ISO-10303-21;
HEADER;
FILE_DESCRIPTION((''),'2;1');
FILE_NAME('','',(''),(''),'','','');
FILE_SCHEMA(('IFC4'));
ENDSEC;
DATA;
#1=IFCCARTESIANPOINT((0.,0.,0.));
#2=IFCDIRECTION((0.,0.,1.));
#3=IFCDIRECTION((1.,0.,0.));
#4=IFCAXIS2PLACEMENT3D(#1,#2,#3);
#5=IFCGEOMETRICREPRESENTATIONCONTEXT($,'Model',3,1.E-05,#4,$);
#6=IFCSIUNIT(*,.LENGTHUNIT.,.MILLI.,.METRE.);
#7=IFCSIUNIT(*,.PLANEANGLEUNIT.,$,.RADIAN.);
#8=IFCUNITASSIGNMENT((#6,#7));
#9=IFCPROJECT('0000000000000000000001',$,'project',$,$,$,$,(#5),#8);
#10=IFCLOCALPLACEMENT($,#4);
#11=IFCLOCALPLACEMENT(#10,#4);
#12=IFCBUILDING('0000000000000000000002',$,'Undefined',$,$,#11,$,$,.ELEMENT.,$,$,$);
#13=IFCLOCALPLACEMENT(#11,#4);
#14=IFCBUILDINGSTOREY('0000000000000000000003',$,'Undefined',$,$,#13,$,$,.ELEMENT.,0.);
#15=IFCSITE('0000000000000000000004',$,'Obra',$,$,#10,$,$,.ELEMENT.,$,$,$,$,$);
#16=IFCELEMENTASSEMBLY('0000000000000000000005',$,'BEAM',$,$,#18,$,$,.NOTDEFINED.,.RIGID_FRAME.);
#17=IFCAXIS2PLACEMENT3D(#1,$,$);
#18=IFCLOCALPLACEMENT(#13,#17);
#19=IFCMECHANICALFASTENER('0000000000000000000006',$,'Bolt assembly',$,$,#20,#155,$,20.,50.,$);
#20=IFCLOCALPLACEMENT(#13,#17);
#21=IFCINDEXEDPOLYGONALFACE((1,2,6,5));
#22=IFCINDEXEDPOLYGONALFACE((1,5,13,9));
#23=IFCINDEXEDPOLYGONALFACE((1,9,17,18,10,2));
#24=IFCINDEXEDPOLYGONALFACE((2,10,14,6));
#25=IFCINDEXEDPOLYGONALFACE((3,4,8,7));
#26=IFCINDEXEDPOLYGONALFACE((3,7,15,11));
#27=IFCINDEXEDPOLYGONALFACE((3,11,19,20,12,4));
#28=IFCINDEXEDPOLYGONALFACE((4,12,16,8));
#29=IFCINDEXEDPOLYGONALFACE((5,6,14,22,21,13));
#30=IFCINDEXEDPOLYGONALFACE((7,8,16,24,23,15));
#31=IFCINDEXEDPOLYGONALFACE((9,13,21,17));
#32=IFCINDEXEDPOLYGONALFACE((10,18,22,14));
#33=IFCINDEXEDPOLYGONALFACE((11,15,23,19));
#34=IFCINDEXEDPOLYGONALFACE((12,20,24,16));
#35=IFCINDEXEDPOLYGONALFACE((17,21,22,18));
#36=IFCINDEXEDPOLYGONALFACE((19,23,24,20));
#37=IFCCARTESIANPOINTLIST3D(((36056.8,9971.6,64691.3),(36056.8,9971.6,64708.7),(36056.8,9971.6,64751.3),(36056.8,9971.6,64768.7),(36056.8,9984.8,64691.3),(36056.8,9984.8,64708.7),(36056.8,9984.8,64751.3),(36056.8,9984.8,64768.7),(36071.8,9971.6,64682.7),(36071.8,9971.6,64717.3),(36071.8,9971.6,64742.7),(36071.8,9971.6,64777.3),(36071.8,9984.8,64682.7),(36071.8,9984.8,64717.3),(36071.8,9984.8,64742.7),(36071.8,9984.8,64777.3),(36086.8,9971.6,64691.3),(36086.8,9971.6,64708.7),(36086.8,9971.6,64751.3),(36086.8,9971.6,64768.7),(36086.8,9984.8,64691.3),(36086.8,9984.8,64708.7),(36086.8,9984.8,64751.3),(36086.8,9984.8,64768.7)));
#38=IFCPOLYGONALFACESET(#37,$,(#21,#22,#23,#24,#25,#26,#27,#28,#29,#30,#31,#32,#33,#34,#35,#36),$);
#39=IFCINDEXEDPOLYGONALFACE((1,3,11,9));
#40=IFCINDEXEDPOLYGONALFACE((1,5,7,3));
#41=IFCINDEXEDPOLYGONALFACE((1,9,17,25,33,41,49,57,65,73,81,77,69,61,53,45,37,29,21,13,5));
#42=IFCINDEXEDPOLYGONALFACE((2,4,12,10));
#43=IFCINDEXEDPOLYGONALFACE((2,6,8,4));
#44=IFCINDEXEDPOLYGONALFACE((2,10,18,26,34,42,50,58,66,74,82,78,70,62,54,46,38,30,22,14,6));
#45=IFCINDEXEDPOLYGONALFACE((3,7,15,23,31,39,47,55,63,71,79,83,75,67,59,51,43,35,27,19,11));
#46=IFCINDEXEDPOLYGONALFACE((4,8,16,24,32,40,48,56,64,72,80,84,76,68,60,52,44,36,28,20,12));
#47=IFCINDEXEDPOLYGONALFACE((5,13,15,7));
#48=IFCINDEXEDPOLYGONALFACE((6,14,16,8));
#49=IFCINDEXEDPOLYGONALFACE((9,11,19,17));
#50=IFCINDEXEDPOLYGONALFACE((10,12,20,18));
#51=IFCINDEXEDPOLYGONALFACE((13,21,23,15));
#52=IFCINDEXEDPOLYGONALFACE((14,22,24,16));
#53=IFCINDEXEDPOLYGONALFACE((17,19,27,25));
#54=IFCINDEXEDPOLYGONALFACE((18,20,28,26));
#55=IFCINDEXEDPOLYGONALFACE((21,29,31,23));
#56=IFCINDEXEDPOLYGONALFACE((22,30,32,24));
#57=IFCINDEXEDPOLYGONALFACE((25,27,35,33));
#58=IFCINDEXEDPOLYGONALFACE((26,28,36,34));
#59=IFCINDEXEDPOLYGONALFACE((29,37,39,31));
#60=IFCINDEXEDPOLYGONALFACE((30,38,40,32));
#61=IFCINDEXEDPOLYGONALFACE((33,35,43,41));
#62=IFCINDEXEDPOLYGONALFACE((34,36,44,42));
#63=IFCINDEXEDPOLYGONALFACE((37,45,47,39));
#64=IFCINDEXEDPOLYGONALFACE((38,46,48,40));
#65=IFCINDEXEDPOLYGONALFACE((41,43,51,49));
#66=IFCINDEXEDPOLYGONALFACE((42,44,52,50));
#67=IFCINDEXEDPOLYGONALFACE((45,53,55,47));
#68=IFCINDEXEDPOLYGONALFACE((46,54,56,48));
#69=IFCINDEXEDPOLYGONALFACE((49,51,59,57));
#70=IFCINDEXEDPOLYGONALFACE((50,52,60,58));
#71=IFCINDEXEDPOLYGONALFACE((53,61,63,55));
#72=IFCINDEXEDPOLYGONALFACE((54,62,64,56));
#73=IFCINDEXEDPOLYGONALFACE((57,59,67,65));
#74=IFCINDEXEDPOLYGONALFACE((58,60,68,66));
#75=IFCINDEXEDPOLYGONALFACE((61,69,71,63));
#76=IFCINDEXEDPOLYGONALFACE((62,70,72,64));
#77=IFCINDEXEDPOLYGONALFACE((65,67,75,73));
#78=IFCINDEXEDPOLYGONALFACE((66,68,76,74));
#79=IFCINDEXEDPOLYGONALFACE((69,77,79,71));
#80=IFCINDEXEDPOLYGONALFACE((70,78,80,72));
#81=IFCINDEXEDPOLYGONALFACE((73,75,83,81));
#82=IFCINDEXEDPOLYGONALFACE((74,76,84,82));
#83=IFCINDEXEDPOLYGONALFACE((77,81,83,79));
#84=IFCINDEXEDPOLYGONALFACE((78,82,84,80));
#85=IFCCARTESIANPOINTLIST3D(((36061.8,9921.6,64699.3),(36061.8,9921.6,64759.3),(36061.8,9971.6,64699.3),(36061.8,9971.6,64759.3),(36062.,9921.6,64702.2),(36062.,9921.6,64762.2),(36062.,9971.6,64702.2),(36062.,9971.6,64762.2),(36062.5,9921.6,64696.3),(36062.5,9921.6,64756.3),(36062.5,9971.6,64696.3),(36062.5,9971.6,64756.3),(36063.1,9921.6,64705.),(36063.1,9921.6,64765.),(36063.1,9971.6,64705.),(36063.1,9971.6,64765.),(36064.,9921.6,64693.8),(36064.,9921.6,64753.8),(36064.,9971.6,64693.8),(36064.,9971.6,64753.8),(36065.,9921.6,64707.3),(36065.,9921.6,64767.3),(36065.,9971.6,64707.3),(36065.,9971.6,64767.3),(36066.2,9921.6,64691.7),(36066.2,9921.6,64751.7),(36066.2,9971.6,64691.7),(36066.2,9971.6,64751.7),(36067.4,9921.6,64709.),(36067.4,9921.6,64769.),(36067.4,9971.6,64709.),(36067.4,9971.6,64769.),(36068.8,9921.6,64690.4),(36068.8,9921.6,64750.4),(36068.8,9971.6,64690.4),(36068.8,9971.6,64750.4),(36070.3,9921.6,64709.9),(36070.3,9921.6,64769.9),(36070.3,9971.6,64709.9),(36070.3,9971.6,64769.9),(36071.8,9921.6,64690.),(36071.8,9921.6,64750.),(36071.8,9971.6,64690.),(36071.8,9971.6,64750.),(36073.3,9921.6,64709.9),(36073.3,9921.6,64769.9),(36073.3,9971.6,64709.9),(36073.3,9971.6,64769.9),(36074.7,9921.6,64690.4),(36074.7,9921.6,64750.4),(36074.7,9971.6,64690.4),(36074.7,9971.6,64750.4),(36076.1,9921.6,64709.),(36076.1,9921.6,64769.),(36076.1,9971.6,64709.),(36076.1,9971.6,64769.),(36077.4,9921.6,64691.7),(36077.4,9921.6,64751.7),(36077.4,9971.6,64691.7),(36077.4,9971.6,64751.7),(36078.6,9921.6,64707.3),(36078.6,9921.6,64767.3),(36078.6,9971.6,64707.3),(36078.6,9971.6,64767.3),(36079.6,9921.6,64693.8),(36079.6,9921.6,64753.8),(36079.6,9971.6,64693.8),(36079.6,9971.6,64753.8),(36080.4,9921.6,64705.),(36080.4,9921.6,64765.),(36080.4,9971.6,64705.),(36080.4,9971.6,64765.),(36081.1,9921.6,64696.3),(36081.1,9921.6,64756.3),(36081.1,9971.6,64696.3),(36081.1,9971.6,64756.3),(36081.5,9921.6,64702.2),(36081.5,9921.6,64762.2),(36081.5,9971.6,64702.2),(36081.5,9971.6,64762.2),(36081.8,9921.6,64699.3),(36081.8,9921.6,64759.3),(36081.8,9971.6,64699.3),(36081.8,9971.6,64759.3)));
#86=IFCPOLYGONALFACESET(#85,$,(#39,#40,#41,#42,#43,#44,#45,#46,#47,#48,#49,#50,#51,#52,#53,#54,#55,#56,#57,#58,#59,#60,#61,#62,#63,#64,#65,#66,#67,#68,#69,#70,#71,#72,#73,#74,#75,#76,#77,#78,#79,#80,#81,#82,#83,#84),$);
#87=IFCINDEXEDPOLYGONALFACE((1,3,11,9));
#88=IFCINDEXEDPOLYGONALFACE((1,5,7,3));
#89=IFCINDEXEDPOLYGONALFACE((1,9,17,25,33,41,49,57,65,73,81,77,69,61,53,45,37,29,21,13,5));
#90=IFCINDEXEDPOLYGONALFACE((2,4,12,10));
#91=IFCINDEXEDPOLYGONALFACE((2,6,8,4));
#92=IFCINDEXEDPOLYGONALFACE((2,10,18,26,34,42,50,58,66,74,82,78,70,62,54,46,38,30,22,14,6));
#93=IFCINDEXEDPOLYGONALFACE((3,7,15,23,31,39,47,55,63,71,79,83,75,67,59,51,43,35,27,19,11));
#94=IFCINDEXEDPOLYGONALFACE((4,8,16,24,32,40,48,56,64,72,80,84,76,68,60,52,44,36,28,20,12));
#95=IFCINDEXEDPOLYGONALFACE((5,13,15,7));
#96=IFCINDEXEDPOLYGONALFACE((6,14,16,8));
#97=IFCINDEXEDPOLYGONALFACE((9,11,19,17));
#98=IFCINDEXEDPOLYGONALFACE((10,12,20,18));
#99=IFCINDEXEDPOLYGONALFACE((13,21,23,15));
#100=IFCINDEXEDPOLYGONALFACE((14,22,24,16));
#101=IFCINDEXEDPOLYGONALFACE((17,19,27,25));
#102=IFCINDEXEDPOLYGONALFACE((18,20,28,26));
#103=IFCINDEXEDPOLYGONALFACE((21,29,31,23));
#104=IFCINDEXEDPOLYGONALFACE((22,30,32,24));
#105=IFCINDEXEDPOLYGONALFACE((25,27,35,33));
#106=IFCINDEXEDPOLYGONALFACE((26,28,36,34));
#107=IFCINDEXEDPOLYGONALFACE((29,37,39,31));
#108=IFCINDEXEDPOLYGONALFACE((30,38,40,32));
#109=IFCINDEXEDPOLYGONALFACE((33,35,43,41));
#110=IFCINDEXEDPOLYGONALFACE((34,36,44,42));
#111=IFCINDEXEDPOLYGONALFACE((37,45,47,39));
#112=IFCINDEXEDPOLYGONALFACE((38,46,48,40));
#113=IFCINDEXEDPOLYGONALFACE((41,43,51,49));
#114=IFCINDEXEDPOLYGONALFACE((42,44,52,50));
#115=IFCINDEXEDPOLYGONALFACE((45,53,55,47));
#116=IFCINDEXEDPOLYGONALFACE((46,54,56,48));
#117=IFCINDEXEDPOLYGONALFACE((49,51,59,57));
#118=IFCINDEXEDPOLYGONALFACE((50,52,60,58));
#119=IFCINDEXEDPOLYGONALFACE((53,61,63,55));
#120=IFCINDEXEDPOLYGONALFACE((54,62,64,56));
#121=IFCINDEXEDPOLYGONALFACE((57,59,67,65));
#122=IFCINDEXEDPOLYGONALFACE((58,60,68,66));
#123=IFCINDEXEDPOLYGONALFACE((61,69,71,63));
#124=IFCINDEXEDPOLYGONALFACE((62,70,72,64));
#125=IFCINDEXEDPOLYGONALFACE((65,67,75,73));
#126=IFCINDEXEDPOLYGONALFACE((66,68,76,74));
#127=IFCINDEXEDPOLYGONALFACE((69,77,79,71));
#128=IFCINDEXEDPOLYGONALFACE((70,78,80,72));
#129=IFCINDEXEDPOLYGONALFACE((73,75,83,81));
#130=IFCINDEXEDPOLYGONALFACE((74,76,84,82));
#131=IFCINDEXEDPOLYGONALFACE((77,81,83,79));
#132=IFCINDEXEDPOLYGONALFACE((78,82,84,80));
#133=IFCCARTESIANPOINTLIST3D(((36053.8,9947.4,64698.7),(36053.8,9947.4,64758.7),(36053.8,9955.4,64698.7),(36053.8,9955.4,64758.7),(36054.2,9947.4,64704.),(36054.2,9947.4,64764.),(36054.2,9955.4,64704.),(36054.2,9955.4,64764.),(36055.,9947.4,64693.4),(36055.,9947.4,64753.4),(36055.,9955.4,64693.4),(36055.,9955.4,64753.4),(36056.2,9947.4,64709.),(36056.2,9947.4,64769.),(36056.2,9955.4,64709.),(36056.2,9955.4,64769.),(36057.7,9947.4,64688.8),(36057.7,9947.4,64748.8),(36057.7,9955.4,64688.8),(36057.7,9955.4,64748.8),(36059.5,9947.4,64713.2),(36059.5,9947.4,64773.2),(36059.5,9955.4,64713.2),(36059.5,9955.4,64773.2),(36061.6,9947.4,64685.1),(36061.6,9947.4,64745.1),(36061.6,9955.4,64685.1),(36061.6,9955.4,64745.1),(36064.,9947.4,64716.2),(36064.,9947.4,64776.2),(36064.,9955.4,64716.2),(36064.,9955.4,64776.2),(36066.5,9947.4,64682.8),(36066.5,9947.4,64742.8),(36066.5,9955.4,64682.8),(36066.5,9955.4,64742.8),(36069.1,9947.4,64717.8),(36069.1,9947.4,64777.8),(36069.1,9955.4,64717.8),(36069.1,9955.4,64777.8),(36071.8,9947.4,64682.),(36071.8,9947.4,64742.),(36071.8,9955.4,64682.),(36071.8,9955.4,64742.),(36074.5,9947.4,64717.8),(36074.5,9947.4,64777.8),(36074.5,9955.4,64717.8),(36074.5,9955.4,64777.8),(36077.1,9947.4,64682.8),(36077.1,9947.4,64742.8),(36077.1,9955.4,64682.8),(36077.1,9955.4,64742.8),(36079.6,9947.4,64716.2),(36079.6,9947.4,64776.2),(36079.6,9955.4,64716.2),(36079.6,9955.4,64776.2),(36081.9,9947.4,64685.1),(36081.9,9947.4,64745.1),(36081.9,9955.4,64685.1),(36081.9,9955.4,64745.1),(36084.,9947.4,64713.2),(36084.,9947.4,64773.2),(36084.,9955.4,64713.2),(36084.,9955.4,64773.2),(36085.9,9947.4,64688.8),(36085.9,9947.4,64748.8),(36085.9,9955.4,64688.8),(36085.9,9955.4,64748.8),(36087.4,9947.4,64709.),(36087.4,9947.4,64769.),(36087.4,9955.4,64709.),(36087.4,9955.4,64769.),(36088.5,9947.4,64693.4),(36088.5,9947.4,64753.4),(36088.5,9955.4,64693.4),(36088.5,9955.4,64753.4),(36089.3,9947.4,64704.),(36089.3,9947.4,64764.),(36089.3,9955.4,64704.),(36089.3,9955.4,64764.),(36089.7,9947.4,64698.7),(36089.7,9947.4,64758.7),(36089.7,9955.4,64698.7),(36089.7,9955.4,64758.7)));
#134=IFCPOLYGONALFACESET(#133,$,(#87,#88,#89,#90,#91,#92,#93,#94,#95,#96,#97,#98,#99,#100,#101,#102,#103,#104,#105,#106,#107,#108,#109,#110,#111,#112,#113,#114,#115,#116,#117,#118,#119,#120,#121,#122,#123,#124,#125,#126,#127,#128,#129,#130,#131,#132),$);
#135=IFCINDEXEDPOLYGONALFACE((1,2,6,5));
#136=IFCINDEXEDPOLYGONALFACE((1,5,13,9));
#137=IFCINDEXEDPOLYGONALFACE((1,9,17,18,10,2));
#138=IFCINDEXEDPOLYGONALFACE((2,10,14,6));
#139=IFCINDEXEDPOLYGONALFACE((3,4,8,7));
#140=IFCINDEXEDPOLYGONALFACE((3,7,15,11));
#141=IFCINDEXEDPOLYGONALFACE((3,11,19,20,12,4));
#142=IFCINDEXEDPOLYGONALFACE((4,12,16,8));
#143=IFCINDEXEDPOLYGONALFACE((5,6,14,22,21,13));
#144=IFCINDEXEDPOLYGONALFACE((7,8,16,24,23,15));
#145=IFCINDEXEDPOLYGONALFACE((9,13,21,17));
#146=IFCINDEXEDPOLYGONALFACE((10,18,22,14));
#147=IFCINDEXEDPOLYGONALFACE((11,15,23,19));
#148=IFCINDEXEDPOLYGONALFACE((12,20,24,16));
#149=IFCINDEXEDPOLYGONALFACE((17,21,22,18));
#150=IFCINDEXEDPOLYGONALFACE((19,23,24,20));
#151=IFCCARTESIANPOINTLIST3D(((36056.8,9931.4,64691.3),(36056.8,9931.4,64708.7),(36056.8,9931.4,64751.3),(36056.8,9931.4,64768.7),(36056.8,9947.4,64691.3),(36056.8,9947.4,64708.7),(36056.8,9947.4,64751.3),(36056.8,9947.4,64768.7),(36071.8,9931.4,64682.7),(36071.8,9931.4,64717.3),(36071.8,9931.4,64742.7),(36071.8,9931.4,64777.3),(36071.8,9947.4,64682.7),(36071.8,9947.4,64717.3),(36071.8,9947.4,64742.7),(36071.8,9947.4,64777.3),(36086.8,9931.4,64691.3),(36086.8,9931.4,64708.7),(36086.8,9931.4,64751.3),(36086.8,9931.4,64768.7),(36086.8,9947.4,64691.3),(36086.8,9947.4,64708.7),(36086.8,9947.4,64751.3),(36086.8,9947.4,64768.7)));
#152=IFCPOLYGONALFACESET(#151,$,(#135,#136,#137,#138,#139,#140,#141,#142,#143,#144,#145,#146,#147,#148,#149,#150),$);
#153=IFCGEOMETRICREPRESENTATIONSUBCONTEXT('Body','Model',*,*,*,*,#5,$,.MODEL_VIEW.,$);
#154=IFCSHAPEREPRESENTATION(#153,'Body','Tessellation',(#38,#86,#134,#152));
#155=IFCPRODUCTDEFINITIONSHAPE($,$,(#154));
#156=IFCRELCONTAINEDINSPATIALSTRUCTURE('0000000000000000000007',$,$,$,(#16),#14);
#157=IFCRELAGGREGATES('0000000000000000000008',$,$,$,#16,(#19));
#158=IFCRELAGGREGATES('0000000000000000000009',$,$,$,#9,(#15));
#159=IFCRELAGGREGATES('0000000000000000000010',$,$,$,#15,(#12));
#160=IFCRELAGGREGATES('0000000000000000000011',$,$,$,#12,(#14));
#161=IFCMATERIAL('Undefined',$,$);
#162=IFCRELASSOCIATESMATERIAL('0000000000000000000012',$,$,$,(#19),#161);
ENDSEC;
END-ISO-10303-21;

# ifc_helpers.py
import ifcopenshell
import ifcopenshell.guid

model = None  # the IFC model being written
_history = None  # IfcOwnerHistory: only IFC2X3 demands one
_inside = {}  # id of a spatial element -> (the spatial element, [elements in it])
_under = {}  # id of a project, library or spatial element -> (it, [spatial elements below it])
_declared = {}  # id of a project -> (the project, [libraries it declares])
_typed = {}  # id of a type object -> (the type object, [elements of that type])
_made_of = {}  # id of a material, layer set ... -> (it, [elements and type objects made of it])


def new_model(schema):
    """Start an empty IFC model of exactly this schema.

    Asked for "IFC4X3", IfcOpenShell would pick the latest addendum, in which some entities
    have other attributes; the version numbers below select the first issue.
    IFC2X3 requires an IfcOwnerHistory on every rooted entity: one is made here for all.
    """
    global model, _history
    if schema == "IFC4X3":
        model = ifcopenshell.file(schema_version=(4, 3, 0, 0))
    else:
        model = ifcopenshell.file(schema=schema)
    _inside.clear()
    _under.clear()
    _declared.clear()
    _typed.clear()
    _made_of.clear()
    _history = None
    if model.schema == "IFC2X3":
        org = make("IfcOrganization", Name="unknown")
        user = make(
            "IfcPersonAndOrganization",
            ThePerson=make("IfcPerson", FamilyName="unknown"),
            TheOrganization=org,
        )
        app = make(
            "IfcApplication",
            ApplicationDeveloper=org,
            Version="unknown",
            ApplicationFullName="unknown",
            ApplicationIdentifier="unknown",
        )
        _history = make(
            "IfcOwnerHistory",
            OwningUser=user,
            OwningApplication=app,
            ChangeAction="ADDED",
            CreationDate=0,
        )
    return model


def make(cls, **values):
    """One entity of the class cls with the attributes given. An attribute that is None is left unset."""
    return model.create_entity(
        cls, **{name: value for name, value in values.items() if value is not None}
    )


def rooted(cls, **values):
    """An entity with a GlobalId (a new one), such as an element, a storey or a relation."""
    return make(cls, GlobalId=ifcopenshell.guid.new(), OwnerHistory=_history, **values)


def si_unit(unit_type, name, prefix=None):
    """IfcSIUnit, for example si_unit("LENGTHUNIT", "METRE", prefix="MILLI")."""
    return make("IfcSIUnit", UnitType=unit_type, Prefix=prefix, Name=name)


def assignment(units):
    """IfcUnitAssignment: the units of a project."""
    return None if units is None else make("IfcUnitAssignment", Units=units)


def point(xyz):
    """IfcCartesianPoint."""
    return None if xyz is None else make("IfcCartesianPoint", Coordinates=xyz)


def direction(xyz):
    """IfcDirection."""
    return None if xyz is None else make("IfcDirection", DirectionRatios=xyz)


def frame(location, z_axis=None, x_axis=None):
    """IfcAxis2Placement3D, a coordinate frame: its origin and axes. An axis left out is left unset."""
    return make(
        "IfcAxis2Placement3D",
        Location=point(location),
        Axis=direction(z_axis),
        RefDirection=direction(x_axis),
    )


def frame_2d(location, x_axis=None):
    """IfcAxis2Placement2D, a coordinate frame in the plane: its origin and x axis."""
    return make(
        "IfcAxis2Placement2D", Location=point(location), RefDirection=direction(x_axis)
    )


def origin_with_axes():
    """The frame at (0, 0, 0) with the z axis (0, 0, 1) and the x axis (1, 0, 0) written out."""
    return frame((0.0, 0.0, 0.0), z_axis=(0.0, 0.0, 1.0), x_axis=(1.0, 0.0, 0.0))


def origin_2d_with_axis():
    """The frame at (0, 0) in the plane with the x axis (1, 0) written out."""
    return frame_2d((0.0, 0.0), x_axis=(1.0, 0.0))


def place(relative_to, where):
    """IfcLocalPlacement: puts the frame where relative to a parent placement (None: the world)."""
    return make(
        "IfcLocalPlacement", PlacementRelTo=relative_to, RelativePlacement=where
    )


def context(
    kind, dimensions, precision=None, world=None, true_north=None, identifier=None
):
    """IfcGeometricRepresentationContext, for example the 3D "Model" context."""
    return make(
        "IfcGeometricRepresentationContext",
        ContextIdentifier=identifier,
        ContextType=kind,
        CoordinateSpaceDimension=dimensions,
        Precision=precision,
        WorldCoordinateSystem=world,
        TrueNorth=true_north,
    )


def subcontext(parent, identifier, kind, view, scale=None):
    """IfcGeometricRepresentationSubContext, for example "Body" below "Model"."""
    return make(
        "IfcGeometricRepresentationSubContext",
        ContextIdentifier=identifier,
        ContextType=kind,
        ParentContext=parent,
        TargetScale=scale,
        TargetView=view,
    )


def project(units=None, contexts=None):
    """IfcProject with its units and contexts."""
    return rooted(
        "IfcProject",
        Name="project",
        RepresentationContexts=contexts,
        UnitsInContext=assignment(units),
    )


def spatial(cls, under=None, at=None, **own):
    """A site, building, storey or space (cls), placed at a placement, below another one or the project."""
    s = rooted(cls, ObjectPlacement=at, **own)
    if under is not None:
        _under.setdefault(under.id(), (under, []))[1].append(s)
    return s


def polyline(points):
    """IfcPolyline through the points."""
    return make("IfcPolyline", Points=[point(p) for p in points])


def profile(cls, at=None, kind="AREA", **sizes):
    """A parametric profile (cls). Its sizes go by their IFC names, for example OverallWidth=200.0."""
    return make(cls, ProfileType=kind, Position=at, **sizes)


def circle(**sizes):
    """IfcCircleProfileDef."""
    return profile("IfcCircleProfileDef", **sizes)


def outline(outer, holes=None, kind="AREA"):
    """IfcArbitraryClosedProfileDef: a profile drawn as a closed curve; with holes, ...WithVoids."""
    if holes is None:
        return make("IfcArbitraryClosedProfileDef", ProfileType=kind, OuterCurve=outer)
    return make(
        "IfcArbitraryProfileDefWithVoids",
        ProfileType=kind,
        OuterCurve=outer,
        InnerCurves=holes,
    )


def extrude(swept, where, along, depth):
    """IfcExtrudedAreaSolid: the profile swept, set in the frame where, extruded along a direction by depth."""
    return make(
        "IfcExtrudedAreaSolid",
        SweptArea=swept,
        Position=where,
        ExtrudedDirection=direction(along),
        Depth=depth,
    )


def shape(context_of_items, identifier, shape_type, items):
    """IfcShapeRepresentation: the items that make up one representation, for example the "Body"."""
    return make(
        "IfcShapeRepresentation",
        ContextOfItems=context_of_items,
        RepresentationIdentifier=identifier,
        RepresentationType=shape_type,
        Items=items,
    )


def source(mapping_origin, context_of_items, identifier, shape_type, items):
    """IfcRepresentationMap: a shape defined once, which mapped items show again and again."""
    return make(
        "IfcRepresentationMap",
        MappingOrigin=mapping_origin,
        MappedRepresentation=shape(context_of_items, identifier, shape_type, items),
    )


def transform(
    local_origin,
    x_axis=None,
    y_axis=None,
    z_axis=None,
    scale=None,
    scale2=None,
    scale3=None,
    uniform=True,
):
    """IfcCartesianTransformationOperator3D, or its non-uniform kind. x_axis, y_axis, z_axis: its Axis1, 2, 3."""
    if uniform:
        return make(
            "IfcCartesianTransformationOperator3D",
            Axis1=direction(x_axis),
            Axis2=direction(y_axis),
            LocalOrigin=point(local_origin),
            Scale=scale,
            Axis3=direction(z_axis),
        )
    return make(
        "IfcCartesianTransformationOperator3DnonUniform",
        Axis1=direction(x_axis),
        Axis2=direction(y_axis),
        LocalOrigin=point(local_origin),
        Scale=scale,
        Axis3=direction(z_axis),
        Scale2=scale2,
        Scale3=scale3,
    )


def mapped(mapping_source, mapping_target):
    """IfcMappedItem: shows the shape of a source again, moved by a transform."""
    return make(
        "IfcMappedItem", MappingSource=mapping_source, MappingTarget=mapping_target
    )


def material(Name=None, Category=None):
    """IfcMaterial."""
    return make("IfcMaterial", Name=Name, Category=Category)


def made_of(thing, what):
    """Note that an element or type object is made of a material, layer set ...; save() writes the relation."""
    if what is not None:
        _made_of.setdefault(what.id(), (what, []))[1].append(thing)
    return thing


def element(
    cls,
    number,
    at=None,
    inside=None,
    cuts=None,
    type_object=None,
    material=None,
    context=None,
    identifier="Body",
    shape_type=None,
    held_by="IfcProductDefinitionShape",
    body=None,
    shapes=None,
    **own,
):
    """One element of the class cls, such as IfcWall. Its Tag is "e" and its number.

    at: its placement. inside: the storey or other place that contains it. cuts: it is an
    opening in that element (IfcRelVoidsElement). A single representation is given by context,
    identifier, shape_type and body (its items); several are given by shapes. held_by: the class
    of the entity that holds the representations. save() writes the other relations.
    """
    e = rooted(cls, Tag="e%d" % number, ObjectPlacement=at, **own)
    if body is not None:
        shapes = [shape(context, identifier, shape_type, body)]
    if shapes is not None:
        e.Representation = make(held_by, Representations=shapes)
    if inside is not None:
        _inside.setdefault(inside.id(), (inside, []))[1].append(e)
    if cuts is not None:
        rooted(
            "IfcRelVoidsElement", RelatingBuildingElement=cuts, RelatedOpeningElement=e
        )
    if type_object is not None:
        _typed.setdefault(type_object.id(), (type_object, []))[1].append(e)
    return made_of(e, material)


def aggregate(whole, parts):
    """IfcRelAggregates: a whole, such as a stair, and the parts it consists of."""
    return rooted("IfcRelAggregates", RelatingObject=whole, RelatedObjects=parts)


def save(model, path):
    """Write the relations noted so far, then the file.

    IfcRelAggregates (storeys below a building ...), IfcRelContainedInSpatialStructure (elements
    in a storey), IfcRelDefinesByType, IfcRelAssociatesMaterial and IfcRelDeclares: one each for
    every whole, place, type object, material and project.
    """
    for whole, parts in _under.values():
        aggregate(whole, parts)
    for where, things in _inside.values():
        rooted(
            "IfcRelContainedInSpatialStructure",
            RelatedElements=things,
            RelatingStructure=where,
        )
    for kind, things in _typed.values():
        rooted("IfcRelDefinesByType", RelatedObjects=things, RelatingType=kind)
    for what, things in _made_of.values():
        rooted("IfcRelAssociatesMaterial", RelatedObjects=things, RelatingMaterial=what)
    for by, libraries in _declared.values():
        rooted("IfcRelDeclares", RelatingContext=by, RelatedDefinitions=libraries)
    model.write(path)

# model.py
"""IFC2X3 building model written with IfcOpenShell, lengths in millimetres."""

from ifc_helpers import new_model, si_unit, frame, origin_with_axes, origin_2d_with_axis, place, context, subcontext, project, spatial, polyline, circle, outline, extrude, source, transform, mapped, material, element, aggregate, save


model = new_model("IFC2X3")

# Units and contexts
model_context = context("Model", 3, precision=1e-05, world=origin_with_axes())
body_context = subcontext(model_context, "Body", "Model", "MODEL_VIEW")
ifc_project = project(units=[si_unit("LENGTHUNIT", "METRE", prefix="MILLI"), si_unit("PLANEANGLEUNIT", "RADIAN")], contexts=[model_context])

# Site, building, storey
site_placement = place(None, origin_with_axes())
site = spatial("IfcSite", under=ifc_project, at=site_placement, Name="Obra", CompositionType="ELEMENT")
building_placement = place(site_placement, origin_with_axes())
building = spatial("IfcBuilding", under=site, at=building_placement, Name="Undefined", CompositionType="ELEMENT")
storey_placement = place(building_placement, origin_with_axes())
storey = spatial("IfcBuildingStorey", under=building, at=storey_placement, Name="Undefined", CompositionType="ELEMENT", Elevation=0.0)

# Shared definitions
ifc_material = material(Name="Undefined")

# Element assembly, mechanical fastener
shared_shape_1 = source(origin_with_axes(), body_context, "Body", "SweptSolid", [
    extrude(outline(polyline([(17.3, 0.0), (8.7, 15.0), (-8.7, 15.0), (-17.3, 0.0), (-8.7, -15.0), (8.7, -15.0), (17.3, 0.0)])), frame((0.0, -26.3, 0.0), z_axis=(0.0, 1.0, 0.0), x_axis=(1.0, 0.0, 0.0)), (0.0, 0.0, 1.0), 13.2),
    extrude(circle(Radius=10.0, at=origin_2d_with_axis()), frame((0.0, -13.1, 0.0), z_axis=(0.0, 1.0, 0.0), x_axis=(1.0, 0.0, 0.0)), (0.0, 0.0, 1.0), 50.0),
    extrude(circle(Radius=18.0, at=origin_2d_with_axis()), frame((0.0, 3.1, 0.0), z_axis=(0.0, 1.0, 0.0), x_axis=(1.0, 0.0, 0.0)), (0.0, 0.0, 1.0), 8.0),
    extrude(outline(polyline([(17.3, 0.0), (8.7, 15.0), (-8.7, 15.0), (-17.3, 0.0), (-8.7, -15.0), (8.7, -15.0), (17.3, 0.0)])), frame((0.0, 11.1, 0.0), z_axis=(0.0, 1.0, 0.0), x_axis=(1.0, 0.0, 0.0)), (0.0, 0.0, 1.0), 16.0),
])
assembly_1_placement = place(storey_placement, origin_with_axes())
assembly_1 = element("IfcElementAssembly", 1, at=assembly_1_placement, inside=storey, Name="BEAM", AssemblyPlace="NOTDEFINED", PredefinedType="RIGID_FRAME")
mechanical_fastener_1_placement = place(assembly_1_placement, frame((36111.8, 9958.5, 64850.0), z_axis=(-1.0, 0.0, 0.0), x_axis=(0.0, 0.0, -1.0)))
mechanical_fastener_1 = element("IfcMechanicalFastener", 2, at=mechanical_fastener_1_placement, material=ifc_material, Name="Bolt assembly", NominalDiameter=20.0, NominalLength=50.0, context=body_context, shape_type="MappedRepresentation", body=[
    mapped(shared_shape_1, transform((90.0, 0.0, 40.0))),
    mapped(shared_shape_1, transform((150.0, 0.0, 40.0))),
])

aggregate(assembly_1, [mechanical_fastener_1])

save(model, "model.ifc")
